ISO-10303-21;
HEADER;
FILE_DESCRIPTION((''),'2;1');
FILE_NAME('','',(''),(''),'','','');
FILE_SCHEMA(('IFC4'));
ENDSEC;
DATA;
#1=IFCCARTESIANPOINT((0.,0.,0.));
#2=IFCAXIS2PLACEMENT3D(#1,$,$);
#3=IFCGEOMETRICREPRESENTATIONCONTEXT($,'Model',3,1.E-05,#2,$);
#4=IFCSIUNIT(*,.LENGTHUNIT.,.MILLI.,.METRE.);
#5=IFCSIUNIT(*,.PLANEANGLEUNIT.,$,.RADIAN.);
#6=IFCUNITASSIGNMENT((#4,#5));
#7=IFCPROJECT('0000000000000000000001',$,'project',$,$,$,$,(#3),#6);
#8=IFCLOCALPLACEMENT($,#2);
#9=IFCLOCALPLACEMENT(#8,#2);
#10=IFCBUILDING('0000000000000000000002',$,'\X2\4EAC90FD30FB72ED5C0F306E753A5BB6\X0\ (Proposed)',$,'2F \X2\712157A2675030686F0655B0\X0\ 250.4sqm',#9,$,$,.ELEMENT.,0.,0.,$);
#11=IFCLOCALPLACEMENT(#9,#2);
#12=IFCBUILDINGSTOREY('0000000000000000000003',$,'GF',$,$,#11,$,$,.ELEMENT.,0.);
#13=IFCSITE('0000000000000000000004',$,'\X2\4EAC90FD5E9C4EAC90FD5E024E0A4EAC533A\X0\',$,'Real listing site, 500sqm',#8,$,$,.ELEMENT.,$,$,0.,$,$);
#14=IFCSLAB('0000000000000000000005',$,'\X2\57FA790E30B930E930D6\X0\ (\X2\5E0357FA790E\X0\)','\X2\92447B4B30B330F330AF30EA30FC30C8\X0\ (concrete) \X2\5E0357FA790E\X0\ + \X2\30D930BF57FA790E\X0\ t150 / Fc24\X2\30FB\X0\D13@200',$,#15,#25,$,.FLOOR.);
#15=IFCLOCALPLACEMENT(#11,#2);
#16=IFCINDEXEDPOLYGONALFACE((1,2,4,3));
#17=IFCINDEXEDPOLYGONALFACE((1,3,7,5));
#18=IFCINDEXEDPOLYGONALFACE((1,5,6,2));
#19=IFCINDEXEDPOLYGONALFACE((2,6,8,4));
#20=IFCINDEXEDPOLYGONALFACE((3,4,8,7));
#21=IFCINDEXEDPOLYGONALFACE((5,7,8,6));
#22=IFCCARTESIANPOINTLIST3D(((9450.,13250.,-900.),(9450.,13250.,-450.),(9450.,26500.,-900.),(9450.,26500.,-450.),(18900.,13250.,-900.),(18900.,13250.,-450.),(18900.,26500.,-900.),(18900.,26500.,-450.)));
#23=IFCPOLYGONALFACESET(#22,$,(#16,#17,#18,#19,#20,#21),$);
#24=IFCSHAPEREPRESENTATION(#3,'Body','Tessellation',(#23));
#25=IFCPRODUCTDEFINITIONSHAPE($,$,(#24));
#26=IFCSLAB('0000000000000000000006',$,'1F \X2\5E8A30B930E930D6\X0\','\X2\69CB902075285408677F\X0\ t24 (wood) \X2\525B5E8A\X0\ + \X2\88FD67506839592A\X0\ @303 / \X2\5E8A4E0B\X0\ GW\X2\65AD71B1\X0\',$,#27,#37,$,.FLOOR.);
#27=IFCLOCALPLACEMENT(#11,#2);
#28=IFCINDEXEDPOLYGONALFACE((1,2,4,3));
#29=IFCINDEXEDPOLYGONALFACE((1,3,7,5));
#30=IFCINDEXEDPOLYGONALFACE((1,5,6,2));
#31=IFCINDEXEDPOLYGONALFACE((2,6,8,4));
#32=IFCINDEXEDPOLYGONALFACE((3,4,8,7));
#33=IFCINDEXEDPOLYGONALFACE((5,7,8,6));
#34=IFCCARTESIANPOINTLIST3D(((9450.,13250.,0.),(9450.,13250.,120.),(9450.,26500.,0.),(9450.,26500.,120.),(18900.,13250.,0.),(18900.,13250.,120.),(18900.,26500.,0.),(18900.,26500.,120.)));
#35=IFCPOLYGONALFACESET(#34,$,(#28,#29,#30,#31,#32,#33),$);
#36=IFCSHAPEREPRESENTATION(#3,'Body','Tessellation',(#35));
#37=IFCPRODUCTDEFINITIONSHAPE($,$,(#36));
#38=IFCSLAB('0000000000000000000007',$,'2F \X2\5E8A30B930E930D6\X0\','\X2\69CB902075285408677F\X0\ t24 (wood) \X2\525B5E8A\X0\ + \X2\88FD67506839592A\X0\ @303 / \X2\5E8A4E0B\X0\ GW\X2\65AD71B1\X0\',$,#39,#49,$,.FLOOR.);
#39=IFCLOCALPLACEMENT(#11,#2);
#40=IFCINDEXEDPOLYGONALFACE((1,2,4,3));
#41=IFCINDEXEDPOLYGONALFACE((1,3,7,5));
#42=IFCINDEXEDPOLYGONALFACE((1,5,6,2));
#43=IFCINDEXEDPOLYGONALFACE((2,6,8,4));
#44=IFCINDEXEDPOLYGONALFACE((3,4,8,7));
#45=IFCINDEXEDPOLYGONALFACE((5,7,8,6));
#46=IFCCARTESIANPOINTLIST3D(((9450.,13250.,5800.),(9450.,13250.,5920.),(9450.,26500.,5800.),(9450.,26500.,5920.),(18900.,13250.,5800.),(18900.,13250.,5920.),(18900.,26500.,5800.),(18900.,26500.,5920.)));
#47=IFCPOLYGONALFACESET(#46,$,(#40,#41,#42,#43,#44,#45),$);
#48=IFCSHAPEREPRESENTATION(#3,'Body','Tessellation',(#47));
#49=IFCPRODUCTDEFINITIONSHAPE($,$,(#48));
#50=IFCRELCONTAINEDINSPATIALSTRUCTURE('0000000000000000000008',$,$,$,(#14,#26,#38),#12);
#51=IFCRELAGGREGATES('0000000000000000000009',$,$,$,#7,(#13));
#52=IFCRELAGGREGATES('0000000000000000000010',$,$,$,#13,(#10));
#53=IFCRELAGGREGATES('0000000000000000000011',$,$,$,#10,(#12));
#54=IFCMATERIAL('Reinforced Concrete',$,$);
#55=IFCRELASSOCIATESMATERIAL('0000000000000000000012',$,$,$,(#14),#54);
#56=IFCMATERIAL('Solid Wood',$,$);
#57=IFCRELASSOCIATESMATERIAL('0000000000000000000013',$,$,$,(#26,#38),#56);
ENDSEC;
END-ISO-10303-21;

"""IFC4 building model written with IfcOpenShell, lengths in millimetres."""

from ifc_helpers import new_model, si_unit, frame, frame_2d, origin, place, context, project, spatial, rectangle, extrude, material, element, save


model = new_model("IFC4")

# Units and contexts
model_context = context("Model", 3, precision=1e-05, world=origin())
ifc_project = project(units=[si_unit("LENGTHUNIT", "METRE", prefix="MILLI"), si_unit("PLANEANGLEUNIT", "RADIAN")], contexts=[model_context])

# Site, building, storey
site_placement = place(None, origin())
site = spatial("IfcSite", under=ifc_project, at=site_placement, Name="京都府京都市上京区", ObjectType="Real listing site, 500sqm", CompositionType="ELEMENT", RefElevation=0.0)
building_placement = place(site_placement, origin())
building = spatial("IfcBuilding", under=site, at=building_placement, Name="京都・狭小の町家 (Proposed)", ObjectType="2F 無垢材と漆喰 250.4sqm", CompositionType="ELEMENT", ElevationOfRefHeight=0.0, ElevationOfTerrain=0.0)
storey_placement = place(building_placement, origin())
storey = spatial("IfcBuildingStorey", under=building, at=storey_placement, Name="GF", CompositionType="ELEMENT", Elevation=0.0)

# Shared definitions
ifc_material_1 = material(Name="Solid Wood")

# Slabs
ifc_material_2 = material(Name="Reinforced Concrete")
slab_1_placement = place(storey_placement, frame((4725.0, 6625.0, -450.0)))
element("IfcSlab", 1, at=slab_1_placement, inside=storey, material=ifc_material_2, Name="基礎スラブ (布基礎)", Description="鉄筋コンクリート (concrete) 布基礎 + ベタ基礎 t150 / Fc24・D13@200", PredefinedType="FLOOR", context=model_context, shape_type="SweptSolid", body=[
    extrude(rectangle(XDim=9450.0, YDim=13250.0, at=frame_2d((4725.0, 6625.0))), frame((4725.0, 6625.0, -450.0)), (0.0, 0.0, 1.0), 450.0),
])
slab_2_placement = place(storey_placement, frame((4725.0, 6625.0, 0.0)))
element("IfcSlab", 2, at=slab_2_placement, inside=storey, material=ifc_material_1, Name="1F 床スラブ", Description="構造用合板 t24 (wood) 剛床 + 製材根太 @303 / 床下 GW断熱", PredefinedType="FLOOR", context=model_context, shape_type="SweptSolid", body=[
    extrude(rectangle(XDim=9450.0, YDim=13250.0, at=frame_2d((4725.0, 6625.0))), frame((4725.0, 6625.0, 0.0)), (0.0, 0.0, 1.0), 120.0),
])
slab_3_placement = place(storey_placement, frame((4725.0, 6625.0, 2900.0)))
element("IfcSlab", 3, at=slab_3_placement, inside=storey, material=ifc_material_1, Name="2F 床スラブ", Description="構造用合板 t24 (wood) 剛床 + 製材根太 @303 / 床下 GW断熱", PredefinedType="FLOOR", context=model_context, shape_type="SweptSolid", body=[
    extrude(rectangle(XDim=9450.0, YDim=13250.0, at=frame_2d((4725.0, 6625.0))), frame((4725.0, 6625.0, 2900.0)), (0.0, 0.0, 1.0), 120.0),
])

save(model, "model.ifc")
